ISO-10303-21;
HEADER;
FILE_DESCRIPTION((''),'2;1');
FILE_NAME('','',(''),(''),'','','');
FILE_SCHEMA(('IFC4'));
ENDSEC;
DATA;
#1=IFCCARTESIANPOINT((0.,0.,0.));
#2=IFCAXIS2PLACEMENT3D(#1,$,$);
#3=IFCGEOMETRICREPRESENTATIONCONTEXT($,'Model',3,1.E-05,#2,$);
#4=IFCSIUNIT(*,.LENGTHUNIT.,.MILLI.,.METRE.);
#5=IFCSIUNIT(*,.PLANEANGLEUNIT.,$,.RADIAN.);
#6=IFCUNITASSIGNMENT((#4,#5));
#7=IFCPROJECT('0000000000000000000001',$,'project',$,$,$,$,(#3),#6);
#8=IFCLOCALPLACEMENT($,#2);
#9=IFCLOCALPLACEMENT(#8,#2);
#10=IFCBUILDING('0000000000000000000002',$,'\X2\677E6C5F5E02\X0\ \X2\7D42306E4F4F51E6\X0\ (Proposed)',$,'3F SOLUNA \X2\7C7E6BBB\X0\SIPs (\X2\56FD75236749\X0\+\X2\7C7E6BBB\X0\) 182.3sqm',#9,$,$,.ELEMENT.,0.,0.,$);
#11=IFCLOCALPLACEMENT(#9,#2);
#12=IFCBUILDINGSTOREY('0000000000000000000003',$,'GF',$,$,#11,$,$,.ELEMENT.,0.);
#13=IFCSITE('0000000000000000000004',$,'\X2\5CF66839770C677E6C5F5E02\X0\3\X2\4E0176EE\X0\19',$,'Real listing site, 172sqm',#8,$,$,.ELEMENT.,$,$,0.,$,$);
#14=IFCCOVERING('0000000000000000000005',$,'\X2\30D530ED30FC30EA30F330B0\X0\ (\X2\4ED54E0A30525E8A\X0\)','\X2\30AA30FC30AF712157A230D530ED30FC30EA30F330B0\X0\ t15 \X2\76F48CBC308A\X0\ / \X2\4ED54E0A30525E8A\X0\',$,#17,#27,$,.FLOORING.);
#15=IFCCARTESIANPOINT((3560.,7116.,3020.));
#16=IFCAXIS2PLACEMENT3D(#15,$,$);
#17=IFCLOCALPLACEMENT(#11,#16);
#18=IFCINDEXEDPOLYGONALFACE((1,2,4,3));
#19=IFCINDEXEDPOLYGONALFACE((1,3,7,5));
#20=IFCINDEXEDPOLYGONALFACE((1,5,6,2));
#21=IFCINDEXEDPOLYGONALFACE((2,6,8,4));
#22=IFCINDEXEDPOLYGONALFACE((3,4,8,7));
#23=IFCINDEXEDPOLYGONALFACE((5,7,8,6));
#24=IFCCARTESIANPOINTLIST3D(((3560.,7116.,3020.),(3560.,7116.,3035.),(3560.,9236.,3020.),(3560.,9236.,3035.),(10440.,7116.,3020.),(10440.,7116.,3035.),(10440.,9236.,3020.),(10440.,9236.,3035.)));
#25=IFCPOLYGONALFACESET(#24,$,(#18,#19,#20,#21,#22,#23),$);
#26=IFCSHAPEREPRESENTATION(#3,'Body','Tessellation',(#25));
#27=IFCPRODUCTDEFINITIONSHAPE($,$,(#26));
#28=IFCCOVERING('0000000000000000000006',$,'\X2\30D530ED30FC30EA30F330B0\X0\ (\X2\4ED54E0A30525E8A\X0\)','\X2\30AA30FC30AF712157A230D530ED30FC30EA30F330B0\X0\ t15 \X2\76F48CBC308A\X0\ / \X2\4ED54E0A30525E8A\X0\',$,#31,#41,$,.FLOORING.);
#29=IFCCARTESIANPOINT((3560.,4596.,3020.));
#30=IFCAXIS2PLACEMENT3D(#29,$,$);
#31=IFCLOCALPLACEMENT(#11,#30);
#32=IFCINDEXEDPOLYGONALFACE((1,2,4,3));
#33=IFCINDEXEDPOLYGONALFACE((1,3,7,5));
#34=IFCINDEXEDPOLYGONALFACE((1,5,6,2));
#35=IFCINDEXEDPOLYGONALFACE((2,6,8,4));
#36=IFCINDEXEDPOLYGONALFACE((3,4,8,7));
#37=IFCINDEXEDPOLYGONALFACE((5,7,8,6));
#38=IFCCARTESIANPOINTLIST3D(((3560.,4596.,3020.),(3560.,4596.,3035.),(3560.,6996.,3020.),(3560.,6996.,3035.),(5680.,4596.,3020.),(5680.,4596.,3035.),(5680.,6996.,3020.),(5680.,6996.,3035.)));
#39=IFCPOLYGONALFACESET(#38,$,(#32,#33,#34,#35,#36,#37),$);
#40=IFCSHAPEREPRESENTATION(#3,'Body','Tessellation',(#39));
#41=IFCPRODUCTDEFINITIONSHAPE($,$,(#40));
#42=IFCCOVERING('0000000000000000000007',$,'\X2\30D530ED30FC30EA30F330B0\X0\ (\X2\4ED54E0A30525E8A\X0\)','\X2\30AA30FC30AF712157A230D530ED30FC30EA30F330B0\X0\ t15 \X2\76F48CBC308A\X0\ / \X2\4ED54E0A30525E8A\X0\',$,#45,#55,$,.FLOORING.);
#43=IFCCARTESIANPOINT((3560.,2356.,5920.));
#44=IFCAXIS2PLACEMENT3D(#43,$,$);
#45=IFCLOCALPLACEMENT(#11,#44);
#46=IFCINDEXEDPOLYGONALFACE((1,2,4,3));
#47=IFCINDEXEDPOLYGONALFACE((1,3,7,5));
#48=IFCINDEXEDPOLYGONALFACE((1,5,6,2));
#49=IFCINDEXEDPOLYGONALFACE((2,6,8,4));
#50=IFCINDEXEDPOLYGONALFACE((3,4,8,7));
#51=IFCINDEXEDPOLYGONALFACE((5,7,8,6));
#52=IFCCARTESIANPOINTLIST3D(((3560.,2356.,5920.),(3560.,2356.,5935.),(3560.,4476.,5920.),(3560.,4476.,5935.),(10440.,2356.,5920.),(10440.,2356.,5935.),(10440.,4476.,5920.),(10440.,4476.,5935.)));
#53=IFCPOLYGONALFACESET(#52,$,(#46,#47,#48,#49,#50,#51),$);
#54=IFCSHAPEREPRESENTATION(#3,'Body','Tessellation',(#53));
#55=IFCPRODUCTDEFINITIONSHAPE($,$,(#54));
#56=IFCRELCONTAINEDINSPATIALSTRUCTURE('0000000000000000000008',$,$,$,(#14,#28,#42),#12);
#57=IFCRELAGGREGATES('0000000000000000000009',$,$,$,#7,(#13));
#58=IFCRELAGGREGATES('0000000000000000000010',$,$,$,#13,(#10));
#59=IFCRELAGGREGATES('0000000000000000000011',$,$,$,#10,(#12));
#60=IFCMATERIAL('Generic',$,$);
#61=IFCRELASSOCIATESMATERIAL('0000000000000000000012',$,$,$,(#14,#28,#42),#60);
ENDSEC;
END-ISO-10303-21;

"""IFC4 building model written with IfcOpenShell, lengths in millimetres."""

from ifc_helpers import new_model, si_unit, frame, frame_2d, origin, place, context, project, spatial, rectangle, extrude, material, element, save


model = new_model("IFC4")

# Units and contexts
model_context = context("Model", 3, precision=1e-05, world=origin())
ifc_project = project(units=[si_unit("LENGTHUNIT", "METRE", prefix="MILLI"), si_unit("PLANEANGLEUNIT", "RADIAN")], contexts=[model_context])

# Site, building, storey
site_placement = place(None, origin())
site = spatial("IfcSite", under=ifc_project, at=site_placement, Name="島根県松江市3丁目19", ObjectType="Real listing site, 172sqm", CompositionType="ELEMENT", RefElevation=0.0)
building_placement = place(site_placement, origin())
building = spatial("IfcBuilding", under=site, at=building_placement, Name="松江市 終の住処 (Proposed)", ObjectType="3F SOLUNA 籾殻SIPs (国産杉+籾殻) 182.3sqm", CompositionType="ELEMENT", ElevationOfRefHeight=0.0, ElevationOfTerrain=0.0)
storey_placement = place(building_placement, origin())
storey = spatial("IfcBuildingStorey", under=building, at=storey_placement, Name="GF", CompositionType="ELEMENT", Elevation=0.0)

# Shared definitions
ifc_material_1 = material(Name="Generic")

# Coverings
covering_1_placement = place(storey_placement, frame((3560.0, 7116.0, 3020.0)))
element("IfcCovering", 1, at=covering_1_placement, inside=storey, material=ifc_material_1, Name="フローリング (仕上げ床)", Description="オーク無垢フローリング t15 直貼り / 仕上げ床", PredefinedType="FLOORING", context=model_context, shape_type="SweptSolid", body=[
    extrude(rectangle(XDim=6880.0, YDim=2120.0, at=frame_2d((3440.0, 1060.0))), frame((3560.0, 7116.0, 3020.0)), (0.0, 0.0, 1.0), 15.0),
])
covering_2_placement = place(storey_placement, frame((3560.0, 4596.0, 3020.0)))
element("IfcCovering", 2, at=covering_2_placement, inside=storey, material=ifc_material_1, Name="フローリング (仕上げ床)", Description="オーク無垢フローリング t15 直貼り / 仕上げ床", PredefinedType="FLOORING", context=model_context, shape_type="SweptSolid", body=[
    extrude(rectangle(XDim=2120.0, YDim=2400.0, at=frame_2d((1060.0, 1200.0))), frame((3560.0, 4596.0, 3020.0)), (0.0, 0.0, 1.0), 15.0),
])
covering_3_placement = place(storey_placement, frame((3560.0, 2356.0, 5920.0)))
element("IfcCovering", 3, at=covering_3_placement, inside=storey, material=ifc_material_1, Name="フローリング (仕上げ床)", Description="オーク無垢フローリング t15 直貼り / 仕上げ床", PredefinedType="FLOORING", context=model_context, shape_type="SweptSolid", body=[
    extrude(rectangle(XDim=6880.0, YDim=2120.0, at=frame_2d((3440.0, 1060.0))), frame((3560.0, 2356.0, 5920.0)), (0.0, 0.0, 1.0), 15.0),
])

save(model, "model.ifc")
